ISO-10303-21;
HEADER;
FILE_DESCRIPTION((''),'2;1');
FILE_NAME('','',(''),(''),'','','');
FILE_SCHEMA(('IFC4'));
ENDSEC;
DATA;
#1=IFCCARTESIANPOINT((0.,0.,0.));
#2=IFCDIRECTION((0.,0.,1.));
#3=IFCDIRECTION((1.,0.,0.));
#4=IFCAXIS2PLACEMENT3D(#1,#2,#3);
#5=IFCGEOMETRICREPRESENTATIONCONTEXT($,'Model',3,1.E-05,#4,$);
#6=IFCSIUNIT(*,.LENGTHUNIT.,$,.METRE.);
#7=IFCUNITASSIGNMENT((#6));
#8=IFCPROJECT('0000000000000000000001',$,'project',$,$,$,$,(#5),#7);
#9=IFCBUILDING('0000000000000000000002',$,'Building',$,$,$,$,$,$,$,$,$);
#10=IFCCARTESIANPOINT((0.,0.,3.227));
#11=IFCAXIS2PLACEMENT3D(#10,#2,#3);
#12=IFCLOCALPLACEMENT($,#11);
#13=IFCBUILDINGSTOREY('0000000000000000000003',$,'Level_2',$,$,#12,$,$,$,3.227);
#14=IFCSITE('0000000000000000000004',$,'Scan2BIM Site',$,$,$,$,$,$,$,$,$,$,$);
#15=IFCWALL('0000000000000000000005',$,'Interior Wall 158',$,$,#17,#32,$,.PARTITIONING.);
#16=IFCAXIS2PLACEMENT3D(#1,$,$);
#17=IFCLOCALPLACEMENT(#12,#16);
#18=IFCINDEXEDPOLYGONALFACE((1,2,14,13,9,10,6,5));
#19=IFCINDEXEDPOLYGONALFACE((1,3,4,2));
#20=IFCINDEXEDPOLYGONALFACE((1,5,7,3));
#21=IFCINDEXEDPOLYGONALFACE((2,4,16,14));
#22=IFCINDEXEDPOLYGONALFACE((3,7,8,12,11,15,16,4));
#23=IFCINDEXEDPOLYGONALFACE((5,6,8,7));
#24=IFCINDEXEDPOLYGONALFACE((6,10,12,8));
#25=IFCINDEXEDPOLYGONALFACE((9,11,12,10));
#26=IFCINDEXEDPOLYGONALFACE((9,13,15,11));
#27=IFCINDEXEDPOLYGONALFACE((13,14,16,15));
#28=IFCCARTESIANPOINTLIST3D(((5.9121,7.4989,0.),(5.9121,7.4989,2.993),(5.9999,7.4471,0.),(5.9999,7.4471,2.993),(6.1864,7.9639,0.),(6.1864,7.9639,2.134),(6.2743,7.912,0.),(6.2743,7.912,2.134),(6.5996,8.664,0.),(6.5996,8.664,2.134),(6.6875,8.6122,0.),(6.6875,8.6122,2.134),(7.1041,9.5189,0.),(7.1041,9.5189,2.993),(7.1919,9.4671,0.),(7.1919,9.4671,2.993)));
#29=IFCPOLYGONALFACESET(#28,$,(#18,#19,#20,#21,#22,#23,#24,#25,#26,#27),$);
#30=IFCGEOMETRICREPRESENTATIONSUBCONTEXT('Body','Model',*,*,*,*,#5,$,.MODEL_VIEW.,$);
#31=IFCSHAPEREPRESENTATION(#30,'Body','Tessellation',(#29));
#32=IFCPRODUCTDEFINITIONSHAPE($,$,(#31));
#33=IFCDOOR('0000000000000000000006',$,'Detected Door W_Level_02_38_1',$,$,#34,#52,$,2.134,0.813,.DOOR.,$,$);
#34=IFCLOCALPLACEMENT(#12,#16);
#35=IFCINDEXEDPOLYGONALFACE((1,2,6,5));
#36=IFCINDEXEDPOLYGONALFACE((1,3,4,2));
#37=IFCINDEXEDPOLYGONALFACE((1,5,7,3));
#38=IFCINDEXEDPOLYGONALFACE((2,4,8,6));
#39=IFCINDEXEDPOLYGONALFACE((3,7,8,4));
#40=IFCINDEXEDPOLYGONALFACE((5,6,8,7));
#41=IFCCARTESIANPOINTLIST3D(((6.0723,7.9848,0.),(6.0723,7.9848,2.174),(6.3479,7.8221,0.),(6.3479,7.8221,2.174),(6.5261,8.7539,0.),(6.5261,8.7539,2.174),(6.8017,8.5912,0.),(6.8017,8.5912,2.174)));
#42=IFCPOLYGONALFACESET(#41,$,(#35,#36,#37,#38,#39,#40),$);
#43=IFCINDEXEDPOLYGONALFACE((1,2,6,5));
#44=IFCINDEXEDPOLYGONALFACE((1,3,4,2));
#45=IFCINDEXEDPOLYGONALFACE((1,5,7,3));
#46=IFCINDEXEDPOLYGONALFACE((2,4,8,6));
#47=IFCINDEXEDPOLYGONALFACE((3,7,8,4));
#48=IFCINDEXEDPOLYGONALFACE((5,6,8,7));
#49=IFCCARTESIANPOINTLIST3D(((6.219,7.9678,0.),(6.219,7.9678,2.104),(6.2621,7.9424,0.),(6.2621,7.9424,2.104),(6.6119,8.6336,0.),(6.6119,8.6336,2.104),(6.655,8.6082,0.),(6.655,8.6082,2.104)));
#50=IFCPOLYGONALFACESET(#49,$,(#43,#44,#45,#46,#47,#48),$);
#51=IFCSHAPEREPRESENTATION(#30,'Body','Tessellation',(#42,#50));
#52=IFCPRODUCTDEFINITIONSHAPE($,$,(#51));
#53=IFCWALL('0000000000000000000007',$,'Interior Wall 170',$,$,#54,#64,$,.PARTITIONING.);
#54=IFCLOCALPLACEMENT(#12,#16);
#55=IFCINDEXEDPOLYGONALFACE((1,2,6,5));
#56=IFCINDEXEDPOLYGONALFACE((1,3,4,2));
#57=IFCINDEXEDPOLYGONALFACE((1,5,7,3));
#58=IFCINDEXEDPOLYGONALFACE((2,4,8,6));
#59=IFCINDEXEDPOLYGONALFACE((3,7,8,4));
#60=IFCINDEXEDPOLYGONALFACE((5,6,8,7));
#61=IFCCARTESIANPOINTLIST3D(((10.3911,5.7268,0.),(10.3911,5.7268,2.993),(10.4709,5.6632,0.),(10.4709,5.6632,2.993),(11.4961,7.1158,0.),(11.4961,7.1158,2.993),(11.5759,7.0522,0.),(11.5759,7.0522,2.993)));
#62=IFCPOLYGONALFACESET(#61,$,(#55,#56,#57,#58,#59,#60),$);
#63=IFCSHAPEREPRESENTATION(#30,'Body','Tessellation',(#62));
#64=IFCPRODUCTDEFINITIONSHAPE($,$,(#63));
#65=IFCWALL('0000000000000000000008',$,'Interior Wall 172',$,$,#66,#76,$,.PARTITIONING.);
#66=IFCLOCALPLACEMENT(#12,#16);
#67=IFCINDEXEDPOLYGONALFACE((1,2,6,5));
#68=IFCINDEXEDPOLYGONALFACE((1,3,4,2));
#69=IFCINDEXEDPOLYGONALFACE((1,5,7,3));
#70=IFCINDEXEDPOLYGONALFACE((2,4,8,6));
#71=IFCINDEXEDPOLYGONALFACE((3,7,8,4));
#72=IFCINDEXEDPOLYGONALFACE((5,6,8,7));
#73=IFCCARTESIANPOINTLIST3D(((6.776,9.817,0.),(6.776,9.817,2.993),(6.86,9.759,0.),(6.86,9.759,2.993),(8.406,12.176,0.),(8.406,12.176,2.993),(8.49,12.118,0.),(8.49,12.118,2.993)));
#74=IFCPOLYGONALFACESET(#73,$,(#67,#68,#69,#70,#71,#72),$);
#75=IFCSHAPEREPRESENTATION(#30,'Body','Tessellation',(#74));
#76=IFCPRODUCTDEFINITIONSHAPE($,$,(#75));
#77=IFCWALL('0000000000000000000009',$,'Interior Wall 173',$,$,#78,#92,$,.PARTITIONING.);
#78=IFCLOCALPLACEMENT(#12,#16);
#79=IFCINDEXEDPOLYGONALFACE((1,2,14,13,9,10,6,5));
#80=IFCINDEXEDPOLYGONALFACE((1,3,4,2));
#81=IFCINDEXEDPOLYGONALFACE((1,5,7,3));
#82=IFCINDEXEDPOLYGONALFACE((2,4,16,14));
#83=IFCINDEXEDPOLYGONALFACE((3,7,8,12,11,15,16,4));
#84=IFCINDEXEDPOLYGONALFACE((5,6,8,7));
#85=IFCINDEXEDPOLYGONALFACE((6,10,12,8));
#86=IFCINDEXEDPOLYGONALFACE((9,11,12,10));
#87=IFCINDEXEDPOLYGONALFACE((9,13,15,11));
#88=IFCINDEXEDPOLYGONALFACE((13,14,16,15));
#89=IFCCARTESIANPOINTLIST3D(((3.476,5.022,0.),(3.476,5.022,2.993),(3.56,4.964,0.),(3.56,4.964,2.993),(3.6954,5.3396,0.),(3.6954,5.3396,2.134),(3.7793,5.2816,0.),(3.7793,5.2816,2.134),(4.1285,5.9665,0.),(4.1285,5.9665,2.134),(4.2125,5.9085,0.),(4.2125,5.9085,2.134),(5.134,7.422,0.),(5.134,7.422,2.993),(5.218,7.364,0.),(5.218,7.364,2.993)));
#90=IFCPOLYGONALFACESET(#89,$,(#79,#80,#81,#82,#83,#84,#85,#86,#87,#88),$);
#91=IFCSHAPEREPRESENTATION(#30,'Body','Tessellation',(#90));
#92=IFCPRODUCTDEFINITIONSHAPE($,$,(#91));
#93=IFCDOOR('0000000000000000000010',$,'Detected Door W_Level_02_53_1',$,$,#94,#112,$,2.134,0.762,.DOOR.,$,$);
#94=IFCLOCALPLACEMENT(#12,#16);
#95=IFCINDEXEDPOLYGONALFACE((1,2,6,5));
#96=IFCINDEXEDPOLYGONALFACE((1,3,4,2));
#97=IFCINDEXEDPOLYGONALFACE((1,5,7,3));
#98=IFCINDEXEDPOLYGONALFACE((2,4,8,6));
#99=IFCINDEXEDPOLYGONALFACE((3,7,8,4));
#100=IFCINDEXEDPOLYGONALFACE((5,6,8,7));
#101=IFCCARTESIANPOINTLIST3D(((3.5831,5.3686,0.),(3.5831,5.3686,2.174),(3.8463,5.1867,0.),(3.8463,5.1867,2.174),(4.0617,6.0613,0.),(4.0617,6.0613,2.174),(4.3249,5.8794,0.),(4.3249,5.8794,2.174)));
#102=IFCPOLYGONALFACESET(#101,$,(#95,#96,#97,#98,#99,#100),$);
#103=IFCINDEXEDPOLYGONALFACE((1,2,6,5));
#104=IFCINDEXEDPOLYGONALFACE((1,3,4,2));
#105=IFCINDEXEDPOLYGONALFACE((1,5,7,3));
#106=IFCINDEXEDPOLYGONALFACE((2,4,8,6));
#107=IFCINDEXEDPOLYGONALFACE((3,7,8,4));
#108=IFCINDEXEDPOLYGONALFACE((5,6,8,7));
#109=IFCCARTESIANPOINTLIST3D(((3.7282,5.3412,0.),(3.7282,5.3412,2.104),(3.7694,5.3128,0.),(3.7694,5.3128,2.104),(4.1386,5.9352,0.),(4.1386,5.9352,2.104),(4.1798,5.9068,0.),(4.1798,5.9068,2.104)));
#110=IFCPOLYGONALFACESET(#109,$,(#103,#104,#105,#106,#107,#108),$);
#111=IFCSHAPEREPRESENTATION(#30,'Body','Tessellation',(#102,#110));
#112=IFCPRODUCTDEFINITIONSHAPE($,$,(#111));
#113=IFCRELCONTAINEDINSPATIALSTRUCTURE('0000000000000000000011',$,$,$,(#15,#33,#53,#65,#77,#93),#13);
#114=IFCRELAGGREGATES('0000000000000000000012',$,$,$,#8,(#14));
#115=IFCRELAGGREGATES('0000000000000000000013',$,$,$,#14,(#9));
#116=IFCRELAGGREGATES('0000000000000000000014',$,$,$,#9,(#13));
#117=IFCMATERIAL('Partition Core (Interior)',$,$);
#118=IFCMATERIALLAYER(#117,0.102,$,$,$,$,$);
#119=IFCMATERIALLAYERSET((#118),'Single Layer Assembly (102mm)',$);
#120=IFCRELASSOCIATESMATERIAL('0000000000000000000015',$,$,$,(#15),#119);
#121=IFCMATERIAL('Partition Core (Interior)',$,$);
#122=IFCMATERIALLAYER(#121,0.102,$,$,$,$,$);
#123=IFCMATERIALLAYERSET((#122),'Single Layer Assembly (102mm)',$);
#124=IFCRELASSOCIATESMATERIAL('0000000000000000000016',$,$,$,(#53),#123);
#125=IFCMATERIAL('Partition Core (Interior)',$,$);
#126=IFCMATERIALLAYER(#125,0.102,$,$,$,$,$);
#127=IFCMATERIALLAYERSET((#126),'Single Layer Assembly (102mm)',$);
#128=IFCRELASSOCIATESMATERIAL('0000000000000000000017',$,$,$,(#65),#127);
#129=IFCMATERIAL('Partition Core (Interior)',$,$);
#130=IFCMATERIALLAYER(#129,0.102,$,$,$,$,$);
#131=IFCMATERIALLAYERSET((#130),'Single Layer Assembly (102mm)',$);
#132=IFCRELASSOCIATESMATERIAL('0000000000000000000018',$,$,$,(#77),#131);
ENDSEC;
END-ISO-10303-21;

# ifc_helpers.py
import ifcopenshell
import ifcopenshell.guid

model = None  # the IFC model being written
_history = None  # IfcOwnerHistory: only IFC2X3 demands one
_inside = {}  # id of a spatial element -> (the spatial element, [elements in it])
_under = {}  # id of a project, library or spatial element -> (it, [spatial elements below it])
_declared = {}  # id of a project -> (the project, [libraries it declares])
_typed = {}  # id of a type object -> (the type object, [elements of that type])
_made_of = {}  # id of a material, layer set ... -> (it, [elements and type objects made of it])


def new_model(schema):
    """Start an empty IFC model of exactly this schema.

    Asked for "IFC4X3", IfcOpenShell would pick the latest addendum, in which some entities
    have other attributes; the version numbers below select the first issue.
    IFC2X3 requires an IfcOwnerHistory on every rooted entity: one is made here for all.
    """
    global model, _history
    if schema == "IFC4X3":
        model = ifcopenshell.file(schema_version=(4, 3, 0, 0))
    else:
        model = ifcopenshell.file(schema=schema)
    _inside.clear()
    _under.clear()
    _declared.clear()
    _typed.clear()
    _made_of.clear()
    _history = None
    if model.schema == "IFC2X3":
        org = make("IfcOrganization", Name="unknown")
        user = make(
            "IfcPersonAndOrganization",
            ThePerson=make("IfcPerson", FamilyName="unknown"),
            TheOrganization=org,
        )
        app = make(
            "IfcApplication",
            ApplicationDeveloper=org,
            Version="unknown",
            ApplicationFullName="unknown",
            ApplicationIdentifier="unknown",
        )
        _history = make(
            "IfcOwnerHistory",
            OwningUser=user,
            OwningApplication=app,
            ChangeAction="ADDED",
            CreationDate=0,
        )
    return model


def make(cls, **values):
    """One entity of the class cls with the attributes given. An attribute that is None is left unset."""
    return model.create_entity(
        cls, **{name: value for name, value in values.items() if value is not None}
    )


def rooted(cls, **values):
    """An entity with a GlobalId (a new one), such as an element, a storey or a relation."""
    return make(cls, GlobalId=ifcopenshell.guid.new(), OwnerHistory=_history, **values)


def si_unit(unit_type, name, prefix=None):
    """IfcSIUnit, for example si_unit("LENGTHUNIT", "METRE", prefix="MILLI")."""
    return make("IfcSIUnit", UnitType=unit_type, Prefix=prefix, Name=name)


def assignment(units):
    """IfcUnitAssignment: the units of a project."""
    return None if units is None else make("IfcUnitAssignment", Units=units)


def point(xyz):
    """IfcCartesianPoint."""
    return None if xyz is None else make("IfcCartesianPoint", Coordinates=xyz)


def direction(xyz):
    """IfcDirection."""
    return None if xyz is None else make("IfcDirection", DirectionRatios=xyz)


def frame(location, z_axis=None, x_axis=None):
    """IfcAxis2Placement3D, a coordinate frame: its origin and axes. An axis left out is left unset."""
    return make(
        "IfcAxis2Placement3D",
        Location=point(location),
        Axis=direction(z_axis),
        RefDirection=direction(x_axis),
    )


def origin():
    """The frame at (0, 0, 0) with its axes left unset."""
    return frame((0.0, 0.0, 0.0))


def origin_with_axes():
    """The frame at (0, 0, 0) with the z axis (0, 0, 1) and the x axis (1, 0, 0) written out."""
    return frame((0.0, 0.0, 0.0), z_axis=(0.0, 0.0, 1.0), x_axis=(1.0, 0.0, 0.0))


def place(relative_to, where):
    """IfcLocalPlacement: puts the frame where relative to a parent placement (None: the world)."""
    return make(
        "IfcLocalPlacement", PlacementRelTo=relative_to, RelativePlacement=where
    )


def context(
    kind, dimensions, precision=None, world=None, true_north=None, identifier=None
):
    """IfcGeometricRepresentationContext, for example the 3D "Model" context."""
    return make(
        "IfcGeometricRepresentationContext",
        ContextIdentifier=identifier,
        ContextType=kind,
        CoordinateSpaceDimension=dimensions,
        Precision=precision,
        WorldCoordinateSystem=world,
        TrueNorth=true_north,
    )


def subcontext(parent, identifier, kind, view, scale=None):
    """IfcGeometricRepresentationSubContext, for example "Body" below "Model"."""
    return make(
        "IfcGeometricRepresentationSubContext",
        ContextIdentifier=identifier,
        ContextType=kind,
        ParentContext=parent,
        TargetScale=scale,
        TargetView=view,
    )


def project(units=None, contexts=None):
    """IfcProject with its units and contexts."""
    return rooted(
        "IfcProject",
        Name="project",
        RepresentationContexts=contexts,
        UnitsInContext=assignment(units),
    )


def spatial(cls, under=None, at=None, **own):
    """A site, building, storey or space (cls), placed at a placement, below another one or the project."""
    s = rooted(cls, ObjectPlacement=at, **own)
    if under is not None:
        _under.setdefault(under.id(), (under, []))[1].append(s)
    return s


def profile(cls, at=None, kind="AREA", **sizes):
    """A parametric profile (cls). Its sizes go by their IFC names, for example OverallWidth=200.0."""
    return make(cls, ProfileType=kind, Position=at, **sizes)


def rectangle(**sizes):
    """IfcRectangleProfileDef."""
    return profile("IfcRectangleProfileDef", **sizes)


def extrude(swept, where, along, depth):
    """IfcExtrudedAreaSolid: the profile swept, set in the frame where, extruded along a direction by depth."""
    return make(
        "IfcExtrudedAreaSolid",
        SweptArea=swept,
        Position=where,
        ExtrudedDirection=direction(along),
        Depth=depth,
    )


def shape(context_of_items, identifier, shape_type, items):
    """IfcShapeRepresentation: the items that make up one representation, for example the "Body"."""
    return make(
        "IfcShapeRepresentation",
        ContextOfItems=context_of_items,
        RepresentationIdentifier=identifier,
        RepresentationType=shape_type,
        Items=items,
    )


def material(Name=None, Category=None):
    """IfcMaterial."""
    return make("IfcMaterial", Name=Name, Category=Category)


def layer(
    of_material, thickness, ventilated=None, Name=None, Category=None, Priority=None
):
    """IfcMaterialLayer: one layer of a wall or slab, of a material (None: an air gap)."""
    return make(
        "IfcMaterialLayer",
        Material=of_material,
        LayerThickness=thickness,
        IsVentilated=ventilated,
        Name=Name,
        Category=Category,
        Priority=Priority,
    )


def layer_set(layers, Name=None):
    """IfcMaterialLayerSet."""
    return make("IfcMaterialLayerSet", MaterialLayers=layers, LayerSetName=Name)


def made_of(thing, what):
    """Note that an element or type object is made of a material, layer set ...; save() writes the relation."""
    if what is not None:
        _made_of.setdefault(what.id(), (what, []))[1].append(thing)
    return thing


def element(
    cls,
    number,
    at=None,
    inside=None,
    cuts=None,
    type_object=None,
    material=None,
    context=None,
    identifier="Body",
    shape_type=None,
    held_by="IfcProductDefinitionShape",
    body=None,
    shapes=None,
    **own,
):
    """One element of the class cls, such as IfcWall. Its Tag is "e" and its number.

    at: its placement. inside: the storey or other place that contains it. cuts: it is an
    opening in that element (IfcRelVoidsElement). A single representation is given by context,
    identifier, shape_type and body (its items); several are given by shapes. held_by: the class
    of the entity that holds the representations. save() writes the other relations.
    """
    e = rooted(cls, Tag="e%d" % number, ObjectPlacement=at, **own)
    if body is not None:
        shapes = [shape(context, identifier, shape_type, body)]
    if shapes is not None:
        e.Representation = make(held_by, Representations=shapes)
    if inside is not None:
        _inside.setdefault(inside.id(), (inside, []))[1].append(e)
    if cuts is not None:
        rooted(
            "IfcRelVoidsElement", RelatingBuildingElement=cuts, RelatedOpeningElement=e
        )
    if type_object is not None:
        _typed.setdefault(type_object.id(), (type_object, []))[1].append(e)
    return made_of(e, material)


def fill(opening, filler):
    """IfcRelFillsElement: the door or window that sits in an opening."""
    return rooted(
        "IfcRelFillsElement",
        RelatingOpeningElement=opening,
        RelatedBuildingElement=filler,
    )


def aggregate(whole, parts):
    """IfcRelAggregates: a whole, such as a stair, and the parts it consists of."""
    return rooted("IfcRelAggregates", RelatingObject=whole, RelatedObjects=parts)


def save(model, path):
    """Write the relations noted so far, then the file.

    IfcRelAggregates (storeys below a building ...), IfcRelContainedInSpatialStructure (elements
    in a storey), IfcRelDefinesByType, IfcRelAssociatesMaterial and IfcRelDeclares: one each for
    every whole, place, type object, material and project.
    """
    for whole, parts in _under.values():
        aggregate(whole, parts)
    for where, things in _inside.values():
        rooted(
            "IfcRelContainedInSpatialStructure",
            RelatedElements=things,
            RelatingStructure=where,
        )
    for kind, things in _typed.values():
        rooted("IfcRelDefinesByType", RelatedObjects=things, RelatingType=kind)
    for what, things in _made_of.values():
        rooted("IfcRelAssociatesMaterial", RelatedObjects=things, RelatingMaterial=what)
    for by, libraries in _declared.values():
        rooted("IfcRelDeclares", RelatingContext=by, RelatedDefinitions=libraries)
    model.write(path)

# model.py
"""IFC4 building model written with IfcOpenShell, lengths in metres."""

from ifc_helpers import new_model, si_unit, frame, origin, origin_with_axes, place, context, subcontext, project, spatial, rectangle, extrude, material, layer, layer_set, element, fill, save


model = new_model("IFC4")

# Units and contexts
model_context = context("Model", 3, precision=1e-05, world=origin_with_axes())
body_context = subcontext(model_context, "Body", "Model", "MODEL_VIEW")
ifc_project = project(units=[si_unit("LENGTHUNIT", "METRE")], contexts=[model_context])

# Site, building, storey
site = spatial("IfcSite", under=ifc_project, Name="Scan2BIM Site")
building = spatial("IfcBuilding", under=site, Name="Building")
storey_placement = place(None, frame((0.0, 0.0, 3.227), z_axis=(0.0, 0.0, 1.0), x_axis=(1.0, 0.0, 0.0)))
storey = spatial("IfcBuildingStorey", under=building, at=storey_placement, Name="Level_2", Elevation=3.227)

# Wall, opening, door
ifc_material_1 = material(Name="Partition Core (Interior)")
ifc_layer_1 = layer(ifc_material_1, 0.102)
ifc_layer_set_1 = layer_set([ifc_layer_1], Name="Single Layer Assembly (102mm)")
wall_1_placement = place(storey_placement, frame((6.552, 8.483, 0.0), z_axis=(0.0, 0.0, 1.0), x_axis=(-0.508212, -0.861232, 0.0)))
wall_1 = element("IfcWall", 1, at=wall_1_placement, inside=storey, material=ifc_layer_set_1, Name="Interior Wall 158", PredefinedType="PARTITIONING", context=body_context, shape_type="SweptSolid", body=[
    extrude(rectangle(XDim=2.3455, YDim=0.102), origin(), (0.0, 0.0, 1.0), 2.993),
])
opening_1_placement = place(None, frame((6.437, 8.288, 3.227), z_axis=(0.0, 0.0, 1.0), x_axis=(-0.508212, -0.861232, 0.0)))
opening_1 = element("IfcOpeningElement", 2, at=opening_1_placement, cuts=wall_1, PredefinedType="OPENING", context=body_context, shape_type="SweptSolid", body=[
    extrude(rectangle(XDim=0.813, YDim=0.202), origin(), (0.0, 0.0, 1.0), 2.134),
])
door_1_placement = place(opening_1_placement, frame((0.0, 0.0, 0.0), z_axis=(0.0, 0.0, 1.0), x_axis=(1.0, 0.0, 0.0)))
door_1 = element("IfcDoor", 3, at=door_1_placement, inside=storey, Name="Detected Door W_Level_02_38_1", OverallHeight=2.134, OverallWidth=0.813, PredefinedType="DOOR", context=body_context, shape_type="SweptSolid", body=[
    extrude(rectangle(XDim=0.893, YDim=0.32), origin(), (0.0, 0.0, 1.0), 2.174),
    extrude(rectangle(XDim=0.773, YDim=0.05), origin(), (0.0, 0.0, 1.0), 2.104),
])
fill(opening_1, door_1)

# Walls
ifc_material_2 = material(Name="Partition Core (Interior)")
ifc_layer_2 = layer(ifc_material_2, 0.102)
ifc_layer_set_2 = layer_set([ifc_layer_2], Name="Single Layer Assembly (102mm)")
wall_2_placement = place(storey_placement, frame((10.9835, 6.3895, 0.0), z_axis=(0.0, 0.0, 1.0), x_axis=(-0.622563, -0.78257, 0.0)))
element("IfcWall", 4, at=wall_2_placement, inside=storey, material=ifc_layer_set_2, Name="Interior Wall 170", PredefinedType="PARTITIONING", context=body_context, shape_type="SweptSolid", body=[
    extrude(rectangle(XDim=1.7749, YDim=0.102), origin(), (0.0, 0.0, 1.0), 2.993),
])
ifc_material_3 = material(Name="Partition Core (Interior)")
ifc_layer_3 = layer(ifc_material_3, 0.102)
ifc_layer_set_3 = layer_set([ifc_layer_3], Name="Single Layer Assembly (102mm)")
wall_3_placement = place(storey_placement, frame((7.633, 10.9675, 0.0), z_axis=(0.0, 0.0, 1.0), x_axis=(-0.568466, -0.822707, 0.0)))
element("IfcWall", 5, at=wall_3_placement, inside=storey, material=ifc_layer_set_3, Name="Interior Wall 172", PredefinedType="PARTITIONING", context=body_context, shape_type="SweptSolid", body=[
    extrude(rectangle(XDim=2.8674, YDim=0.102), origin(), (0.0, 0.0, 1.0), 2.993),
])

# Wall, opening, door
ifc_material_4 = material(Name="Partition Core (Interior)")
ifc_layer_4 = layer(ifc_material_4, 0.102)
ifc_layer_set_4 = layer_set([ifc_layer_4], Name="Single Layer Assembly (102mm)")
wall_4_placement = place(storey_placement, frame((4.347, 6.193, 0.0), z_axis=(0.0, 0.0, 1.0), x_axis=(-0.56839, -0.822759, 0.0)))
wall_4 = element("IfcWall", 6, at=wall_4_placement, inside=storey, material=ifc_layer_set_4, Name="Interior Wall 173", PredefinedType="PARTITIONING", context=body_context, shape_type="SweptSolid", body=[
    extrude(rectangle(XDim=2.917, YDim=0.102), origin(), (0.0, 0.0, 1.0), 2.993),
])
opening_2_placement = place(None, frame((3.954, 5.624, 3.227), z_axis=(0.0, 0.0, 1.0), x_axis=(-0.56839, -0.822759, 0.0)))
opening_2 = element("IfcOpeningElement", 7, at=opening_2_placement, cuts=wall_4, PredefinedType="OPENING", context=body_context, shape_type="SweptSolid", body=[
    extrude(rectangle(XDim=0.762, YDim=0.202), origin(), (0.0, 0.0, 1.0), 2.134),
])
door_2_placement = place(opening_2_placement, frame((0.0, 0.0, 0.0), z_axis=(0.0, 0.0, 1.0), x_axis=(1.0, 0.0, 0.0)))
door_2 = element("IfcDoor", 8, at=door_2_placement, inside=storey, Name="Detected Door W_Level_02_53_1", OverallHeight=2.134, OverallWidth=0.762, PredefinedType="DOOR", context=body_context, shape_type="SweptSolid", body=[
    extrude(rectangle(XDim=0.842, YDim=0.32), origin(), (0.0, 0.0, 1.0), 2.174),
    extrude(rectangle(XDim=0.722, YDim=0.05), origin(), (0.0, 0.0, 1.0), 2.104),
])
fill(opening_2, door_2)

save(model, "model.ifc")
